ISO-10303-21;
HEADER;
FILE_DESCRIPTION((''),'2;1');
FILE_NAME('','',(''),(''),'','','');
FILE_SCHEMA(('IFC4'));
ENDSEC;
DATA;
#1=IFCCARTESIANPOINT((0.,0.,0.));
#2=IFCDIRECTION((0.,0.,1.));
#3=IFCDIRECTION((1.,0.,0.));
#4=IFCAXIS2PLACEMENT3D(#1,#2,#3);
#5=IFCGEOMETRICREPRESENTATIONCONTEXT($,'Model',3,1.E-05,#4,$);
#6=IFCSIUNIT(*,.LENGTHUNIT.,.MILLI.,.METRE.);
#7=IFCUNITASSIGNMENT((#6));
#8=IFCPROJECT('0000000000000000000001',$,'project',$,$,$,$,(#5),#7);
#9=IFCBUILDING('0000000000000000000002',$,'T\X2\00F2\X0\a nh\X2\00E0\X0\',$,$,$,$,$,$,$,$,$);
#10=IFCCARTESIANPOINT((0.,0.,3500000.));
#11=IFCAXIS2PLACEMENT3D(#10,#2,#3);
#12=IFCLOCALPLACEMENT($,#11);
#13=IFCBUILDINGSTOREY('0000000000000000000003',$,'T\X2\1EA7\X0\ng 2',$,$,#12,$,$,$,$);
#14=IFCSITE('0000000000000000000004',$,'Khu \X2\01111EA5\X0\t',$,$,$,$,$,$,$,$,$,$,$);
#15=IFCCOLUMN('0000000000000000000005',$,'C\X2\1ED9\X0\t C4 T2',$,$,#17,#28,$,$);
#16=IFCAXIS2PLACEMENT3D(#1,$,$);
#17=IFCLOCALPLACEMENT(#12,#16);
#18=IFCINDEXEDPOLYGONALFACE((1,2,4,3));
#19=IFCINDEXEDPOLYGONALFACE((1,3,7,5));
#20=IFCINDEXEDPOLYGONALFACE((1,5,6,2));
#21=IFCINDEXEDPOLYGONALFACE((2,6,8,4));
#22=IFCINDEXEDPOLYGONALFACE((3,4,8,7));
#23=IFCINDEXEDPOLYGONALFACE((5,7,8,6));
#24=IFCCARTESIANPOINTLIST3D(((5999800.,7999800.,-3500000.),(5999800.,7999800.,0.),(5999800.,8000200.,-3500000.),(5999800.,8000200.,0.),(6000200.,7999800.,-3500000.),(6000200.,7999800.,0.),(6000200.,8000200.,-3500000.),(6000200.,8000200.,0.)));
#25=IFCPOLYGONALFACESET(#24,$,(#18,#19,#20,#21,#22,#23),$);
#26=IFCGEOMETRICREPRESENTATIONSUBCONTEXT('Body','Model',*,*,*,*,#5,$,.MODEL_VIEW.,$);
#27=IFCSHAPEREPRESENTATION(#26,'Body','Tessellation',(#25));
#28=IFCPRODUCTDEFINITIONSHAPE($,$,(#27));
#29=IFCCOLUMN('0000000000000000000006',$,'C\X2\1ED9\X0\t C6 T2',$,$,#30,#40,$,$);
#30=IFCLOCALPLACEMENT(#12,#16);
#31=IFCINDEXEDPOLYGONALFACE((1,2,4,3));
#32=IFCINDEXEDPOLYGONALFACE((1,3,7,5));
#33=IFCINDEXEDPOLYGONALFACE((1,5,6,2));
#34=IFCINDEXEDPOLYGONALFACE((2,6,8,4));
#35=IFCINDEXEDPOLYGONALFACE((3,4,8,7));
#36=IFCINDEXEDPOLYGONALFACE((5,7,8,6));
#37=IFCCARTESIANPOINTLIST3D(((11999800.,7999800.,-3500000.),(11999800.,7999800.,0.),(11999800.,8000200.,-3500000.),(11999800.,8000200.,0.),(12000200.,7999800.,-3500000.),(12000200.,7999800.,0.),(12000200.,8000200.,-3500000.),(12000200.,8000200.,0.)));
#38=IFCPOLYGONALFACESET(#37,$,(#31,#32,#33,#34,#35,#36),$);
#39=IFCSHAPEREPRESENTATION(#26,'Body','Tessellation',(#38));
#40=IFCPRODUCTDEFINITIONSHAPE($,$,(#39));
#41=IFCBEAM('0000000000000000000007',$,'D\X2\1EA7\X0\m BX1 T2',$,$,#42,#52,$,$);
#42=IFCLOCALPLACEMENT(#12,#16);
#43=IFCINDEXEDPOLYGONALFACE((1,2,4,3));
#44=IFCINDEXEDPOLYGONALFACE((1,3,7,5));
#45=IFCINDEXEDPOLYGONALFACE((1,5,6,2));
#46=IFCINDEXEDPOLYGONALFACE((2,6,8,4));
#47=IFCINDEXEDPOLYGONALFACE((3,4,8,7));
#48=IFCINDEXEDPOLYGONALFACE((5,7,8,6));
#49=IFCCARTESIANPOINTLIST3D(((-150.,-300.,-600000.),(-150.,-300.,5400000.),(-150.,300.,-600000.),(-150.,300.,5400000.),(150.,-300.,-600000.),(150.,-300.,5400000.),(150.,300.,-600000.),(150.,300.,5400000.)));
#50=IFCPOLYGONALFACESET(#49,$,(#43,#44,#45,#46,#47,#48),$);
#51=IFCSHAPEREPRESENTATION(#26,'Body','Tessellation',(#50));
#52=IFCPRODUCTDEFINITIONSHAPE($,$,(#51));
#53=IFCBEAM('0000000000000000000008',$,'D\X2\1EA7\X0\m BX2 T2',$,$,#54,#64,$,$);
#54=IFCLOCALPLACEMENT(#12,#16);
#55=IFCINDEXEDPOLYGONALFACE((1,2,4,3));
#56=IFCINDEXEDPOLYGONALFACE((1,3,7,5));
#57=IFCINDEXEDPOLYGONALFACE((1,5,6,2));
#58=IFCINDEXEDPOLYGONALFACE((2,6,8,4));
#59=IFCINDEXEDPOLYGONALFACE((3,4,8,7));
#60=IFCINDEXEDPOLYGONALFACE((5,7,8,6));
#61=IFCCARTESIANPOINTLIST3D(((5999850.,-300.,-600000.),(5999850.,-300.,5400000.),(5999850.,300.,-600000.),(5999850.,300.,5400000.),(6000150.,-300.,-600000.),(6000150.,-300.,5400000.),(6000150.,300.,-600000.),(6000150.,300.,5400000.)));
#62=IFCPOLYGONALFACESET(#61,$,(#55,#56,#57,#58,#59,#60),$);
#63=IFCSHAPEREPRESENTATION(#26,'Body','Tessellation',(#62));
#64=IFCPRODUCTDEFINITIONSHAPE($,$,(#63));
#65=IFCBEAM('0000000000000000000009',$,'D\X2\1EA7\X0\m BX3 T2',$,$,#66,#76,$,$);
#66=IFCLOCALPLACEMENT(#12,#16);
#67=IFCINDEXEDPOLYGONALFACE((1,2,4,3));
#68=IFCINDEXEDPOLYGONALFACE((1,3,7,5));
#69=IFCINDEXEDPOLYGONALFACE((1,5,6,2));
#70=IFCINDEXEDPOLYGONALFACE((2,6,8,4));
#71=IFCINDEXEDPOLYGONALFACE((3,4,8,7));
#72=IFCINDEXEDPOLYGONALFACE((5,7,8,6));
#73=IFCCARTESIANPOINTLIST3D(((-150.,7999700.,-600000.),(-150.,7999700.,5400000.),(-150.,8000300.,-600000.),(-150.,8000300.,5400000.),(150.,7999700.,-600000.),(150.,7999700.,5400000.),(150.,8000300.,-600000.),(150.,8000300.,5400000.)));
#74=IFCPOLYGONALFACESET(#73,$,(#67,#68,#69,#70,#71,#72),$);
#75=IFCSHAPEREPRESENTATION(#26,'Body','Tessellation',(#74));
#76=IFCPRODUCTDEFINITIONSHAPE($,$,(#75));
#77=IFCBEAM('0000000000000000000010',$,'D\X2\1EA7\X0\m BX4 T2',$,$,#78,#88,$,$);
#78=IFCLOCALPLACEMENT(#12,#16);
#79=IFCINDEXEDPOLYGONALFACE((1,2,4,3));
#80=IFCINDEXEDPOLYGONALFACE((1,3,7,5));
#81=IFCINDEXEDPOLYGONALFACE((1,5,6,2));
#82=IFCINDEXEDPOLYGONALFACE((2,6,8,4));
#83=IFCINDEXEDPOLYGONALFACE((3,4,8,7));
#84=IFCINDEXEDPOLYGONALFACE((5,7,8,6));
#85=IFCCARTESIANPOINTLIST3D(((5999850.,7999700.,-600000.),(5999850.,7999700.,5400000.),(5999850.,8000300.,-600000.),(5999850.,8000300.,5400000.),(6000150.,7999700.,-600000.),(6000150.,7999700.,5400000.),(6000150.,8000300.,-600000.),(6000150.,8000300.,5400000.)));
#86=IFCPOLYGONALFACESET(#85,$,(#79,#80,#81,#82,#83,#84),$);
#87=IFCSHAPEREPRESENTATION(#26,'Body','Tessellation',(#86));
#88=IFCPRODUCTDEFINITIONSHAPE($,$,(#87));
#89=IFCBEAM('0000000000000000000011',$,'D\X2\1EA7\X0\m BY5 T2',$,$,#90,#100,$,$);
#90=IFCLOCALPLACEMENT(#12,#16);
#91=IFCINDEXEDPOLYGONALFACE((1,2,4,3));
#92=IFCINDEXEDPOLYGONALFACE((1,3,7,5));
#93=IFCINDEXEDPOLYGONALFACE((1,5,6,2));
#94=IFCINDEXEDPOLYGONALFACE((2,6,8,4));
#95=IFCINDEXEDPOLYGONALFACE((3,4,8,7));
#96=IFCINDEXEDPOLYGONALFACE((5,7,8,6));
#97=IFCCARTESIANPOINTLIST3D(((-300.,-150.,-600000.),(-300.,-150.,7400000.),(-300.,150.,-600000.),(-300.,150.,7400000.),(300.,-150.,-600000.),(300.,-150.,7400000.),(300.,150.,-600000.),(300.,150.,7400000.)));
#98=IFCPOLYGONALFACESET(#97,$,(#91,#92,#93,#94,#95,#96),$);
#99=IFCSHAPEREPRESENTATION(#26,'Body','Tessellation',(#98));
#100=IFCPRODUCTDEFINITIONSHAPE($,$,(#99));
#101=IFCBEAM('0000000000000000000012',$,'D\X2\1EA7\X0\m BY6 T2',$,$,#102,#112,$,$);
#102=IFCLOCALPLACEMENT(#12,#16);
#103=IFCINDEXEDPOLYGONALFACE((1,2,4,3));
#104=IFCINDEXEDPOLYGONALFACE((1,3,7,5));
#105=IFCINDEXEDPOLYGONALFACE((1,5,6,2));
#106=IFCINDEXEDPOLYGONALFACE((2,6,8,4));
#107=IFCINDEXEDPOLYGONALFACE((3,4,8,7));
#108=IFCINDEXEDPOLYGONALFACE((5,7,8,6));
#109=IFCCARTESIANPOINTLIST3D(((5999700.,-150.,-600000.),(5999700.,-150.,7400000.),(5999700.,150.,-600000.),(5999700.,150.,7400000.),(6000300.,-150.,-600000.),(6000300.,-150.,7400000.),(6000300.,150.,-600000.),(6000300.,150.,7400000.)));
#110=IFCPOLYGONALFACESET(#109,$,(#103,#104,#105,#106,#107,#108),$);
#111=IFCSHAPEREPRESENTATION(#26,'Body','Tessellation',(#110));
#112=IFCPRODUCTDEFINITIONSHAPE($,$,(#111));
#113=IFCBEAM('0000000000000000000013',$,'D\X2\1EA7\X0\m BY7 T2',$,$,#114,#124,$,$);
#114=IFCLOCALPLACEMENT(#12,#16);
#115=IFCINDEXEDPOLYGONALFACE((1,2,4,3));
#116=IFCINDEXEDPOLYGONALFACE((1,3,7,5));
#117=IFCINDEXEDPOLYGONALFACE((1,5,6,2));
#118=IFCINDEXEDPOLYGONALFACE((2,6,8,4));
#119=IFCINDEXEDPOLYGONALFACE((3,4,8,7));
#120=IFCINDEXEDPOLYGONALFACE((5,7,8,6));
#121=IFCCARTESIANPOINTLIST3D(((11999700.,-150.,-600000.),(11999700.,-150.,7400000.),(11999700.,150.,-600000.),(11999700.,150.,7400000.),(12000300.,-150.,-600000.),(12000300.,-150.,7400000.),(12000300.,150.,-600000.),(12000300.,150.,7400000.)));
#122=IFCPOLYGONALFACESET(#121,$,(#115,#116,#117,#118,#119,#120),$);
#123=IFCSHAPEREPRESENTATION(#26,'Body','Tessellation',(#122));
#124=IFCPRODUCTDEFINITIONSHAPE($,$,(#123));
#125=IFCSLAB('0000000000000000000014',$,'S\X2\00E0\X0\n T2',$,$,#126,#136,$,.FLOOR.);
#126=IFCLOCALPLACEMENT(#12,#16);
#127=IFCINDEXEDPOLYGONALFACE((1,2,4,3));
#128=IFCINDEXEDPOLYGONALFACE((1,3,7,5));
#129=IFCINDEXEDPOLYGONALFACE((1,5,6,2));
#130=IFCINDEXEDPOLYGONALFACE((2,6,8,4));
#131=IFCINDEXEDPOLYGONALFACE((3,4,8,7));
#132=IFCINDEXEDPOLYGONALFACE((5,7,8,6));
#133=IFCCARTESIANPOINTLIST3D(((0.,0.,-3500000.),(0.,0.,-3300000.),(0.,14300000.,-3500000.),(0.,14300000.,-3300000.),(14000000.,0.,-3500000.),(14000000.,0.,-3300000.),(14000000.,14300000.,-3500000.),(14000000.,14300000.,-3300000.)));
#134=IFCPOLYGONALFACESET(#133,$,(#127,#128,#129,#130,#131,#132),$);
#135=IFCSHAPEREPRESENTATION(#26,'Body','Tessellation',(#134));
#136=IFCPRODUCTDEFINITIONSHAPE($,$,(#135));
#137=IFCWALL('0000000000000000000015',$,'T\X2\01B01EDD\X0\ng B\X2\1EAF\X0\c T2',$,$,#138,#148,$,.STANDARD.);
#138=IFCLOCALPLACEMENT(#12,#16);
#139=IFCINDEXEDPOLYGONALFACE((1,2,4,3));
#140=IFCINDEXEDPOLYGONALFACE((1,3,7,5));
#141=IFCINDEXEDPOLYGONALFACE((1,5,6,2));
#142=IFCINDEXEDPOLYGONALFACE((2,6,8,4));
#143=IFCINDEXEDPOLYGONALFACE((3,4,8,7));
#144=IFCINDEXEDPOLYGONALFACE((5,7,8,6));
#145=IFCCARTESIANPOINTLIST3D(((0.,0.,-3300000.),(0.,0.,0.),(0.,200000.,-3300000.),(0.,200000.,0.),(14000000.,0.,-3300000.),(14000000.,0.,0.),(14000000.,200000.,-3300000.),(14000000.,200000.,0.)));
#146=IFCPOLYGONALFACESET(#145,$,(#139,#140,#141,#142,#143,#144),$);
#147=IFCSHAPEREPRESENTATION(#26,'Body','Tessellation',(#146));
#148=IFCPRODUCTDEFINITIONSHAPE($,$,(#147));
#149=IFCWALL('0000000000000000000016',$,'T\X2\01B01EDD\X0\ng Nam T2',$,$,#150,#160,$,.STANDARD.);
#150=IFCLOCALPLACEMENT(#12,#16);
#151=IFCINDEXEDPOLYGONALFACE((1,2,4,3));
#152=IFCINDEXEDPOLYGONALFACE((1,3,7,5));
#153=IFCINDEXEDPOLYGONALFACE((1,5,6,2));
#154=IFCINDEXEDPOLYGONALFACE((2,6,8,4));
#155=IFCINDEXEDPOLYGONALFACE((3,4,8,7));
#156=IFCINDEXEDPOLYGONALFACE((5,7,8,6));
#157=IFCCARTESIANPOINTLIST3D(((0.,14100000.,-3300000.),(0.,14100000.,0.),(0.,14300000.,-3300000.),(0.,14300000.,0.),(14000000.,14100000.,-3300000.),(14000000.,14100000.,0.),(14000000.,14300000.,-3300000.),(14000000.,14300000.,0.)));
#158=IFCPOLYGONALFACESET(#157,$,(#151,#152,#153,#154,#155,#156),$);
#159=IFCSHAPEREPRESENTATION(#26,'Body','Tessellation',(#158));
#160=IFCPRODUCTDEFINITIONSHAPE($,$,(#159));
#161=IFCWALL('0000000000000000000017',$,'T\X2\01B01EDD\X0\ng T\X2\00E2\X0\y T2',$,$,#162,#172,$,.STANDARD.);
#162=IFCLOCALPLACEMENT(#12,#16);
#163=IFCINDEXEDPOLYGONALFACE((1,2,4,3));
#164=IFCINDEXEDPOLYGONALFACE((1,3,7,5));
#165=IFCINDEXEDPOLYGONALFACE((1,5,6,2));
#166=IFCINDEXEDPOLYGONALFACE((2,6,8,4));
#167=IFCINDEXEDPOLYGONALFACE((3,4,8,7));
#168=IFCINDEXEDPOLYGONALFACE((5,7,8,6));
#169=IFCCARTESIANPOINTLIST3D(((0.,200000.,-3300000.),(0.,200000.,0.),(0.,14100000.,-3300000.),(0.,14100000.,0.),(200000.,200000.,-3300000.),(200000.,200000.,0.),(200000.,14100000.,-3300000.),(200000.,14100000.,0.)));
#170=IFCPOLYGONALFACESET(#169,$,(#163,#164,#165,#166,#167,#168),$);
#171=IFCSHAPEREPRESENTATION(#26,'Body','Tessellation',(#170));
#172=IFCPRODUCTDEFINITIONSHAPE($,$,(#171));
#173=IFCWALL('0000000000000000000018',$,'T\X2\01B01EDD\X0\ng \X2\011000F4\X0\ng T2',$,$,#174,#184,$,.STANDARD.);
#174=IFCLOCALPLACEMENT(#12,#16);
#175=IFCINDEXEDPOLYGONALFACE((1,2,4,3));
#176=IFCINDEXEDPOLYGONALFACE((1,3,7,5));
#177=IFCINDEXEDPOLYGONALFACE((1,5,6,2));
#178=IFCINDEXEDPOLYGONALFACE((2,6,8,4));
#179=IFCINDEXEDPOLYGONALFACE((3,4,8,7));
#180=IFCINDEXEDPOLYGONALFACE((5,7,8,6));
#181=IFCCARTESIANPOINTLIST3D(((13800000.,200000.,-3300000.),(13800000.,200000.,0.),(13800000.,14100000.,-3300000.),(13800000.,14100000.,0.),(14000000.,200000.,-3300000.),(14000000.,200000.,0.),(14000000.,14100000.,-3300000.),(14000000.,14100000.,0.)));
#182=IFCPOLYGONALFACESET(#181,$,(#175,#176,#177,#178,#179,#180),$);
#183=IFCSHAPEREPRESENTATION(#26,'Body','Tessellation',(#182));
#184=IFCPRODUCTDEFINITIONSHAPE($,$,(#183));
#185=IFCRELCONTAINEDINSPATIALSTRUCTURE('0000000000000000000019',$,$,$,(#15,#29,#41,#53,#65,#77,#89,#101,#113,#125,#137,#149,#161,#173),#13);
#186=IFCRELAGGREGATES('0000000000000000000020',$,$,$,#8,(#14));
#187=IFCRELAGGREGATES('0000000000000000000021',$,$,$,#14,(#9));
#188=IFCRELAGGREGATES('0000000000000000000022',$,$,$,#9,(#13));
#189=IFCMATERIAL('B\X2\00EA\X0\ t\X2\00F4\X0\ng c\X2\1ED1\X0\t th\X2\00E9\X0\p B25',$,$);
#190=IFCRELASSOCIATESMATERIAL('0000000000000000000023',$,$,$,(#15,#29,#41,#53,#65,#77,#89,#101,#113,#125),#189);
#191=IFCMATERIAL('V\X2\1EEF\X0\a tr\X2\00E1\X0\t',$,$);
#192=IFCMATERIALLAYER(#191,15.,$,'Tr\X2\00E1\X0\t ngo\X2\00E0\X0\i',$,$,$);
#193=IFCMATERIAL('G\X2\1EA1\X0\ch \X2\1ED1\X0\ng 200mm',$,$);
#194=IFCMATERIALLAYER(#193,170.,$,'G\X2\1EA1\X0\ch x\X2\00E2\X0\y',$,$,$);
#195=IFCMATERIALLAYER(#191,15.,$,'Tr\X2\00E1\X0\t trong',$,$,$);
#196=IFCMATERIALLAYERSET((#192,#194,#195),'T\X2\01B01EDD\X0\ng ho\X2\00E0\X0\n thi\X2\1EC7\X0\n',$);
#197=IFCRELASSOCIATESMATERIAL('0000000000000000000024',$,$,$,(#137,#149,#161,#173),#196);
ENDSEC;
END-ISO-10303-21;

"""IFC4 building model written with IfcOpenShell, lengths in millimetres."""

from ifc_helpers import new_model, entity, si_unit, frame, origin_with_axes, place, context, subcontext, project, spatial, indexed_curve, outline, extrude, material, layer, layer_set, layer_usage, element, save


model = new_model("IFC4")

# Units and contexts
model_context = context("Model", 3, precision=1e-05, world=origin_with_axes())
body_context = subcontext(model_context, "Body", "Model", "MODEL_VIEW")
ifc_project = project(units=[si_unit("LENGTHUNIT", "METRE", prefix="MILLI")], contexts=[model_context])

# Site, building, storey
site = spatial("IfcSite", under=ifc_project, Name="Khu đất")
building = spatial("IfcBuilding", under=site, Name="Tòa nhà")
storey_placement = place(None, frame((0.0, 0.0, 3500000.0), z_axis=(0.0, 0.0, 1.0), x_axis=(1.0, 0.0, 0.0)))
storey = spatial("IfcBuildingStorey", under=building, at=storey_placement, Name="Tầng 2")

# Columns
ifc_material_1 = material(Name="Bê tông cốt thép B25")
for number, where, z_axis, x_axis, name in (
    (1, (6000000.0, 8000000.0, -3500000.0), (0.0, 0.0, 1.0), (1.0, 0.0, 0.0), "Cột C4 T2"),
    (2, (12000000.0, 8000000.0, -3500000.0), (0.0, 0.0, 1.0), (1.0, 0.0, 0.0), "Cột C6 T2"),
):
    element("IfcColumn", number, at=place(storey_placement, frame(where, z_axis=z_axis, x_axis=x_axis)), inside=storey, material=ifc_material_1, Name=name, context=body_context, shape_type="SweptSolid", body=[
        extrude(entity("IfcRectangleProfileDef", None, None, None, 400.0, 400.0), origin_with_axes(), (0.0, 0.0, 1.0), 3500000.0),
    ])

# Beams
for number, where, z_axis, x_axis, name in (
    (3, (0.0, 0.0, -600000.0), (0.0, 0.0, 1.0), (1.0, 0.0, 0.0), "Dầm BX1 T2"),
    (4, (6000000.0, 0.0, -600000.0), (0.0, 0.0, 1.0), (1.0, 0.0, 0.0), "Dầm BX2 T2"),
    (5, (0.0, 8000000.0, -600000.0), (0.0, 0.0, 1.0), (1.0, 0.0, 0.0), "Dầm BX3 T2"),
    (6, (6000000.0, 8000000.0, -600000.0), (0.0, 0.0, 1.0), (1.0, 0.0, 0.0), "Dầm BX4 T2"),
):
    element("IfcBeam", number, at=place(storey_placement, frame(where, z_axis=z_axis, x_axis=x_axis)), inside=storey, material=ifc_material_1, Name=name, context=body_context, shape_type="SweptSolid", body=[
        extrude(entity("IfcRectangleProfileDef", None, None, None, 300.0, 600.0), origin_with_axes(), (0.0, 0.0, 1.0), 6000000.0),
    ])
for number, where, z_axis, x_axis, name in (
    (7, (0.0, 0.0, -600000.0), (0.0, 0.0, 1.0), (0.0, 1.0, 0.0), "Dầm BY5 T2"),
    (8, (6000000.0, 0.0, -600000.0), (0.0, 0.0, 1.0), (0.0, 1.0, 0.0), "Dầm BY6 T2"),
    (9, (12000000.0, 0.0, -600000.0), (0.0, 0.0, 1.0), (0.0, 1.0, 0.0), "Dầm BY7 T2"),
):
    element("IfcBeam", number, at=place(storey_placement, frame(where, z_axis=z_axis, x_axis=x_axis)), inside=storey, material=ifc_material_1, Name=name, context=body_context, shape_type="SweptSolid", body=[
        extrude(entity("IfcRectangleProfileDef", None, None, None, 300.0, 600.0), origin_with_axes(), (0.0, 0.0, 1.0), 8000000.0),
    ])

# Slab
slab_placement = place(storey_placement, frame((0.0, 0.0, -3500000.0), z_axis=(0.0, 0.0, 1.0), x_axis=(1.0, 0.0, 0.0)))
element("IfcSlab", 10, at=slab_placement, inside=storey, material=ifc_material_1, Name="Sàn T2", PredefinedType="FLOOR", context=body_context, shape_type="SweptSolid", body=[
    extrude(outline(indexed_curve([(0.0, 0.0), (14000000.0, 0.0), (14000000.0, 14300000.0), (0.0, 14300000.0), (0.0, 0.0)])), None, (0.0, 0.0, 1.0), 200000.0),
])

# Walls
ifc_material_2 = material(Name="Vữa trát")
ifc_layer_1 = layer(ifc_material_2, 15.0, Name="Trát ngoài")
ifc_material_3 = material(Name="Gạch ống 200mm")
ifc_layer_2 = layer(ifc_material_3, 170.0, Name="Gạch xây")
ifc_layer_3 = layer(ifc_material_2, 15.0, Name="Trát trong")
ifc_layer_set = layer_set([ifc_layer_1, ifc_layer_2, ifc_layer_3], Name="Tường hoàn thiện")
ifc_layer_usage_1 = layer_usage(ifc_layer_set, "AXIS2", "POSITIVE", 0.0)
wall_1_placement = place(storey_placement, frame((0.0, 0.0, -3300000.0), z_axis=(0.0, 0.0, 1.0), x_axis=(1.0, 0.0, 0.0)))
element("IfcWall", 11, at=wall_1_placement, inside=storey, material=ifc_layer_usage_1, Name="Tường Bắc T2", PredefinedType="STANDARD", context=body_context, shape_type="SweptSolid", body=[
    extrude(outline(indexed_curve([(0.0, 0.0), (0.0, 200000.0), (14000000.0, 200000.0), (14000000.0, 0.0), (0.0, 0.0)], self_intersect=False)), origin_with_axes(), (0.0, 0.0, 1.0), 3300000.0),
])
ifc_layer_usage_2 = layer_usage(ifc_layer_set, "AXIS2", "POSITIVE", 0.0)
wall_2_placement = place(storey_placement, frame((0.0, 14100000.0, -3300000.0), z_axis=(0.0, 0.0, 1.0), x_axis=(1.0, 0.0, 0.0)))
element("IfcWall", 12, at=wall_2_placement, inside=storey, material=ifc_layer_usage_2, Name="Tường Nam T2", PredefinedType="STANDARD", context=body_context, shape_type="SweptSolid", body=[
    extrude(outline(indexed_curve([(0.0, 0.0), (0.0, 200000.0), (14000000.0, 200000.0), (14000000.0, 0.0), (0.0, 0.0)], self_intersect=False)), origin_with_axes(), (0.0, 0.0, 1.0), 3300000.0),
])
ifc_layer_usage_3 = layer_usage(ifc_layer_set, "AXIS2", "POSITIVE", 0.0)
wall_3_placement = place(storey_placement, frame((0.0, 200000.0, -3300000.0), z_axis=(0.0, 0.0, 1.0), x_axis=(1.0, 0.0, 0.0)))
element("IfcWall", 13, at=wall_3_placement, inside=storey, material=ifc_layer_usage_3, Name="Tường Tây T2", PredefinedType="STANDARD", context=body_context, shape_type="SweptSolid", body=[
    extrude(outline(indexed_curve([(0.0, 0.0), (0.0, 13900000.0), (200000.0, 13900000.0), (200000.0, 0.0), (0.0, 0.0)], self_intersect=False)), origin_with_axes(), (0.0, 0.0, 1.0), 3300000.0),
])
ifc_layer_usage_4 = layer_usage(ifc_layer_set, "AXIS2", "POSITIVE", 0.0)
wall_4_placement = place(storey_placement, frame((13800000.0, 200000.0, -3300000.0), z_axis=(0.0, 0.0, 1.0), x_axis=(1.0, 0.0, 0.0)))
element("IfcWall", 14, at=wall_4_placement, inside=storey, material=ifc_layer_usage_4, Name="Tường Đông T2", PredefinedType="STANDARD", context=body_context, shape_type="SweptSolid", body=[
    extrude(outline(indexed_curve([(0.0, 0.0), (0.0, 13900000.0), (200000.0, 13900000.0), (200000.0, 0.0), (0.0, 0.0)], self_intersect=False)), origin_with_axes(), (0.0, 0.0, 1.0), 3300000.0),
])

save(model, "model.ifc")
